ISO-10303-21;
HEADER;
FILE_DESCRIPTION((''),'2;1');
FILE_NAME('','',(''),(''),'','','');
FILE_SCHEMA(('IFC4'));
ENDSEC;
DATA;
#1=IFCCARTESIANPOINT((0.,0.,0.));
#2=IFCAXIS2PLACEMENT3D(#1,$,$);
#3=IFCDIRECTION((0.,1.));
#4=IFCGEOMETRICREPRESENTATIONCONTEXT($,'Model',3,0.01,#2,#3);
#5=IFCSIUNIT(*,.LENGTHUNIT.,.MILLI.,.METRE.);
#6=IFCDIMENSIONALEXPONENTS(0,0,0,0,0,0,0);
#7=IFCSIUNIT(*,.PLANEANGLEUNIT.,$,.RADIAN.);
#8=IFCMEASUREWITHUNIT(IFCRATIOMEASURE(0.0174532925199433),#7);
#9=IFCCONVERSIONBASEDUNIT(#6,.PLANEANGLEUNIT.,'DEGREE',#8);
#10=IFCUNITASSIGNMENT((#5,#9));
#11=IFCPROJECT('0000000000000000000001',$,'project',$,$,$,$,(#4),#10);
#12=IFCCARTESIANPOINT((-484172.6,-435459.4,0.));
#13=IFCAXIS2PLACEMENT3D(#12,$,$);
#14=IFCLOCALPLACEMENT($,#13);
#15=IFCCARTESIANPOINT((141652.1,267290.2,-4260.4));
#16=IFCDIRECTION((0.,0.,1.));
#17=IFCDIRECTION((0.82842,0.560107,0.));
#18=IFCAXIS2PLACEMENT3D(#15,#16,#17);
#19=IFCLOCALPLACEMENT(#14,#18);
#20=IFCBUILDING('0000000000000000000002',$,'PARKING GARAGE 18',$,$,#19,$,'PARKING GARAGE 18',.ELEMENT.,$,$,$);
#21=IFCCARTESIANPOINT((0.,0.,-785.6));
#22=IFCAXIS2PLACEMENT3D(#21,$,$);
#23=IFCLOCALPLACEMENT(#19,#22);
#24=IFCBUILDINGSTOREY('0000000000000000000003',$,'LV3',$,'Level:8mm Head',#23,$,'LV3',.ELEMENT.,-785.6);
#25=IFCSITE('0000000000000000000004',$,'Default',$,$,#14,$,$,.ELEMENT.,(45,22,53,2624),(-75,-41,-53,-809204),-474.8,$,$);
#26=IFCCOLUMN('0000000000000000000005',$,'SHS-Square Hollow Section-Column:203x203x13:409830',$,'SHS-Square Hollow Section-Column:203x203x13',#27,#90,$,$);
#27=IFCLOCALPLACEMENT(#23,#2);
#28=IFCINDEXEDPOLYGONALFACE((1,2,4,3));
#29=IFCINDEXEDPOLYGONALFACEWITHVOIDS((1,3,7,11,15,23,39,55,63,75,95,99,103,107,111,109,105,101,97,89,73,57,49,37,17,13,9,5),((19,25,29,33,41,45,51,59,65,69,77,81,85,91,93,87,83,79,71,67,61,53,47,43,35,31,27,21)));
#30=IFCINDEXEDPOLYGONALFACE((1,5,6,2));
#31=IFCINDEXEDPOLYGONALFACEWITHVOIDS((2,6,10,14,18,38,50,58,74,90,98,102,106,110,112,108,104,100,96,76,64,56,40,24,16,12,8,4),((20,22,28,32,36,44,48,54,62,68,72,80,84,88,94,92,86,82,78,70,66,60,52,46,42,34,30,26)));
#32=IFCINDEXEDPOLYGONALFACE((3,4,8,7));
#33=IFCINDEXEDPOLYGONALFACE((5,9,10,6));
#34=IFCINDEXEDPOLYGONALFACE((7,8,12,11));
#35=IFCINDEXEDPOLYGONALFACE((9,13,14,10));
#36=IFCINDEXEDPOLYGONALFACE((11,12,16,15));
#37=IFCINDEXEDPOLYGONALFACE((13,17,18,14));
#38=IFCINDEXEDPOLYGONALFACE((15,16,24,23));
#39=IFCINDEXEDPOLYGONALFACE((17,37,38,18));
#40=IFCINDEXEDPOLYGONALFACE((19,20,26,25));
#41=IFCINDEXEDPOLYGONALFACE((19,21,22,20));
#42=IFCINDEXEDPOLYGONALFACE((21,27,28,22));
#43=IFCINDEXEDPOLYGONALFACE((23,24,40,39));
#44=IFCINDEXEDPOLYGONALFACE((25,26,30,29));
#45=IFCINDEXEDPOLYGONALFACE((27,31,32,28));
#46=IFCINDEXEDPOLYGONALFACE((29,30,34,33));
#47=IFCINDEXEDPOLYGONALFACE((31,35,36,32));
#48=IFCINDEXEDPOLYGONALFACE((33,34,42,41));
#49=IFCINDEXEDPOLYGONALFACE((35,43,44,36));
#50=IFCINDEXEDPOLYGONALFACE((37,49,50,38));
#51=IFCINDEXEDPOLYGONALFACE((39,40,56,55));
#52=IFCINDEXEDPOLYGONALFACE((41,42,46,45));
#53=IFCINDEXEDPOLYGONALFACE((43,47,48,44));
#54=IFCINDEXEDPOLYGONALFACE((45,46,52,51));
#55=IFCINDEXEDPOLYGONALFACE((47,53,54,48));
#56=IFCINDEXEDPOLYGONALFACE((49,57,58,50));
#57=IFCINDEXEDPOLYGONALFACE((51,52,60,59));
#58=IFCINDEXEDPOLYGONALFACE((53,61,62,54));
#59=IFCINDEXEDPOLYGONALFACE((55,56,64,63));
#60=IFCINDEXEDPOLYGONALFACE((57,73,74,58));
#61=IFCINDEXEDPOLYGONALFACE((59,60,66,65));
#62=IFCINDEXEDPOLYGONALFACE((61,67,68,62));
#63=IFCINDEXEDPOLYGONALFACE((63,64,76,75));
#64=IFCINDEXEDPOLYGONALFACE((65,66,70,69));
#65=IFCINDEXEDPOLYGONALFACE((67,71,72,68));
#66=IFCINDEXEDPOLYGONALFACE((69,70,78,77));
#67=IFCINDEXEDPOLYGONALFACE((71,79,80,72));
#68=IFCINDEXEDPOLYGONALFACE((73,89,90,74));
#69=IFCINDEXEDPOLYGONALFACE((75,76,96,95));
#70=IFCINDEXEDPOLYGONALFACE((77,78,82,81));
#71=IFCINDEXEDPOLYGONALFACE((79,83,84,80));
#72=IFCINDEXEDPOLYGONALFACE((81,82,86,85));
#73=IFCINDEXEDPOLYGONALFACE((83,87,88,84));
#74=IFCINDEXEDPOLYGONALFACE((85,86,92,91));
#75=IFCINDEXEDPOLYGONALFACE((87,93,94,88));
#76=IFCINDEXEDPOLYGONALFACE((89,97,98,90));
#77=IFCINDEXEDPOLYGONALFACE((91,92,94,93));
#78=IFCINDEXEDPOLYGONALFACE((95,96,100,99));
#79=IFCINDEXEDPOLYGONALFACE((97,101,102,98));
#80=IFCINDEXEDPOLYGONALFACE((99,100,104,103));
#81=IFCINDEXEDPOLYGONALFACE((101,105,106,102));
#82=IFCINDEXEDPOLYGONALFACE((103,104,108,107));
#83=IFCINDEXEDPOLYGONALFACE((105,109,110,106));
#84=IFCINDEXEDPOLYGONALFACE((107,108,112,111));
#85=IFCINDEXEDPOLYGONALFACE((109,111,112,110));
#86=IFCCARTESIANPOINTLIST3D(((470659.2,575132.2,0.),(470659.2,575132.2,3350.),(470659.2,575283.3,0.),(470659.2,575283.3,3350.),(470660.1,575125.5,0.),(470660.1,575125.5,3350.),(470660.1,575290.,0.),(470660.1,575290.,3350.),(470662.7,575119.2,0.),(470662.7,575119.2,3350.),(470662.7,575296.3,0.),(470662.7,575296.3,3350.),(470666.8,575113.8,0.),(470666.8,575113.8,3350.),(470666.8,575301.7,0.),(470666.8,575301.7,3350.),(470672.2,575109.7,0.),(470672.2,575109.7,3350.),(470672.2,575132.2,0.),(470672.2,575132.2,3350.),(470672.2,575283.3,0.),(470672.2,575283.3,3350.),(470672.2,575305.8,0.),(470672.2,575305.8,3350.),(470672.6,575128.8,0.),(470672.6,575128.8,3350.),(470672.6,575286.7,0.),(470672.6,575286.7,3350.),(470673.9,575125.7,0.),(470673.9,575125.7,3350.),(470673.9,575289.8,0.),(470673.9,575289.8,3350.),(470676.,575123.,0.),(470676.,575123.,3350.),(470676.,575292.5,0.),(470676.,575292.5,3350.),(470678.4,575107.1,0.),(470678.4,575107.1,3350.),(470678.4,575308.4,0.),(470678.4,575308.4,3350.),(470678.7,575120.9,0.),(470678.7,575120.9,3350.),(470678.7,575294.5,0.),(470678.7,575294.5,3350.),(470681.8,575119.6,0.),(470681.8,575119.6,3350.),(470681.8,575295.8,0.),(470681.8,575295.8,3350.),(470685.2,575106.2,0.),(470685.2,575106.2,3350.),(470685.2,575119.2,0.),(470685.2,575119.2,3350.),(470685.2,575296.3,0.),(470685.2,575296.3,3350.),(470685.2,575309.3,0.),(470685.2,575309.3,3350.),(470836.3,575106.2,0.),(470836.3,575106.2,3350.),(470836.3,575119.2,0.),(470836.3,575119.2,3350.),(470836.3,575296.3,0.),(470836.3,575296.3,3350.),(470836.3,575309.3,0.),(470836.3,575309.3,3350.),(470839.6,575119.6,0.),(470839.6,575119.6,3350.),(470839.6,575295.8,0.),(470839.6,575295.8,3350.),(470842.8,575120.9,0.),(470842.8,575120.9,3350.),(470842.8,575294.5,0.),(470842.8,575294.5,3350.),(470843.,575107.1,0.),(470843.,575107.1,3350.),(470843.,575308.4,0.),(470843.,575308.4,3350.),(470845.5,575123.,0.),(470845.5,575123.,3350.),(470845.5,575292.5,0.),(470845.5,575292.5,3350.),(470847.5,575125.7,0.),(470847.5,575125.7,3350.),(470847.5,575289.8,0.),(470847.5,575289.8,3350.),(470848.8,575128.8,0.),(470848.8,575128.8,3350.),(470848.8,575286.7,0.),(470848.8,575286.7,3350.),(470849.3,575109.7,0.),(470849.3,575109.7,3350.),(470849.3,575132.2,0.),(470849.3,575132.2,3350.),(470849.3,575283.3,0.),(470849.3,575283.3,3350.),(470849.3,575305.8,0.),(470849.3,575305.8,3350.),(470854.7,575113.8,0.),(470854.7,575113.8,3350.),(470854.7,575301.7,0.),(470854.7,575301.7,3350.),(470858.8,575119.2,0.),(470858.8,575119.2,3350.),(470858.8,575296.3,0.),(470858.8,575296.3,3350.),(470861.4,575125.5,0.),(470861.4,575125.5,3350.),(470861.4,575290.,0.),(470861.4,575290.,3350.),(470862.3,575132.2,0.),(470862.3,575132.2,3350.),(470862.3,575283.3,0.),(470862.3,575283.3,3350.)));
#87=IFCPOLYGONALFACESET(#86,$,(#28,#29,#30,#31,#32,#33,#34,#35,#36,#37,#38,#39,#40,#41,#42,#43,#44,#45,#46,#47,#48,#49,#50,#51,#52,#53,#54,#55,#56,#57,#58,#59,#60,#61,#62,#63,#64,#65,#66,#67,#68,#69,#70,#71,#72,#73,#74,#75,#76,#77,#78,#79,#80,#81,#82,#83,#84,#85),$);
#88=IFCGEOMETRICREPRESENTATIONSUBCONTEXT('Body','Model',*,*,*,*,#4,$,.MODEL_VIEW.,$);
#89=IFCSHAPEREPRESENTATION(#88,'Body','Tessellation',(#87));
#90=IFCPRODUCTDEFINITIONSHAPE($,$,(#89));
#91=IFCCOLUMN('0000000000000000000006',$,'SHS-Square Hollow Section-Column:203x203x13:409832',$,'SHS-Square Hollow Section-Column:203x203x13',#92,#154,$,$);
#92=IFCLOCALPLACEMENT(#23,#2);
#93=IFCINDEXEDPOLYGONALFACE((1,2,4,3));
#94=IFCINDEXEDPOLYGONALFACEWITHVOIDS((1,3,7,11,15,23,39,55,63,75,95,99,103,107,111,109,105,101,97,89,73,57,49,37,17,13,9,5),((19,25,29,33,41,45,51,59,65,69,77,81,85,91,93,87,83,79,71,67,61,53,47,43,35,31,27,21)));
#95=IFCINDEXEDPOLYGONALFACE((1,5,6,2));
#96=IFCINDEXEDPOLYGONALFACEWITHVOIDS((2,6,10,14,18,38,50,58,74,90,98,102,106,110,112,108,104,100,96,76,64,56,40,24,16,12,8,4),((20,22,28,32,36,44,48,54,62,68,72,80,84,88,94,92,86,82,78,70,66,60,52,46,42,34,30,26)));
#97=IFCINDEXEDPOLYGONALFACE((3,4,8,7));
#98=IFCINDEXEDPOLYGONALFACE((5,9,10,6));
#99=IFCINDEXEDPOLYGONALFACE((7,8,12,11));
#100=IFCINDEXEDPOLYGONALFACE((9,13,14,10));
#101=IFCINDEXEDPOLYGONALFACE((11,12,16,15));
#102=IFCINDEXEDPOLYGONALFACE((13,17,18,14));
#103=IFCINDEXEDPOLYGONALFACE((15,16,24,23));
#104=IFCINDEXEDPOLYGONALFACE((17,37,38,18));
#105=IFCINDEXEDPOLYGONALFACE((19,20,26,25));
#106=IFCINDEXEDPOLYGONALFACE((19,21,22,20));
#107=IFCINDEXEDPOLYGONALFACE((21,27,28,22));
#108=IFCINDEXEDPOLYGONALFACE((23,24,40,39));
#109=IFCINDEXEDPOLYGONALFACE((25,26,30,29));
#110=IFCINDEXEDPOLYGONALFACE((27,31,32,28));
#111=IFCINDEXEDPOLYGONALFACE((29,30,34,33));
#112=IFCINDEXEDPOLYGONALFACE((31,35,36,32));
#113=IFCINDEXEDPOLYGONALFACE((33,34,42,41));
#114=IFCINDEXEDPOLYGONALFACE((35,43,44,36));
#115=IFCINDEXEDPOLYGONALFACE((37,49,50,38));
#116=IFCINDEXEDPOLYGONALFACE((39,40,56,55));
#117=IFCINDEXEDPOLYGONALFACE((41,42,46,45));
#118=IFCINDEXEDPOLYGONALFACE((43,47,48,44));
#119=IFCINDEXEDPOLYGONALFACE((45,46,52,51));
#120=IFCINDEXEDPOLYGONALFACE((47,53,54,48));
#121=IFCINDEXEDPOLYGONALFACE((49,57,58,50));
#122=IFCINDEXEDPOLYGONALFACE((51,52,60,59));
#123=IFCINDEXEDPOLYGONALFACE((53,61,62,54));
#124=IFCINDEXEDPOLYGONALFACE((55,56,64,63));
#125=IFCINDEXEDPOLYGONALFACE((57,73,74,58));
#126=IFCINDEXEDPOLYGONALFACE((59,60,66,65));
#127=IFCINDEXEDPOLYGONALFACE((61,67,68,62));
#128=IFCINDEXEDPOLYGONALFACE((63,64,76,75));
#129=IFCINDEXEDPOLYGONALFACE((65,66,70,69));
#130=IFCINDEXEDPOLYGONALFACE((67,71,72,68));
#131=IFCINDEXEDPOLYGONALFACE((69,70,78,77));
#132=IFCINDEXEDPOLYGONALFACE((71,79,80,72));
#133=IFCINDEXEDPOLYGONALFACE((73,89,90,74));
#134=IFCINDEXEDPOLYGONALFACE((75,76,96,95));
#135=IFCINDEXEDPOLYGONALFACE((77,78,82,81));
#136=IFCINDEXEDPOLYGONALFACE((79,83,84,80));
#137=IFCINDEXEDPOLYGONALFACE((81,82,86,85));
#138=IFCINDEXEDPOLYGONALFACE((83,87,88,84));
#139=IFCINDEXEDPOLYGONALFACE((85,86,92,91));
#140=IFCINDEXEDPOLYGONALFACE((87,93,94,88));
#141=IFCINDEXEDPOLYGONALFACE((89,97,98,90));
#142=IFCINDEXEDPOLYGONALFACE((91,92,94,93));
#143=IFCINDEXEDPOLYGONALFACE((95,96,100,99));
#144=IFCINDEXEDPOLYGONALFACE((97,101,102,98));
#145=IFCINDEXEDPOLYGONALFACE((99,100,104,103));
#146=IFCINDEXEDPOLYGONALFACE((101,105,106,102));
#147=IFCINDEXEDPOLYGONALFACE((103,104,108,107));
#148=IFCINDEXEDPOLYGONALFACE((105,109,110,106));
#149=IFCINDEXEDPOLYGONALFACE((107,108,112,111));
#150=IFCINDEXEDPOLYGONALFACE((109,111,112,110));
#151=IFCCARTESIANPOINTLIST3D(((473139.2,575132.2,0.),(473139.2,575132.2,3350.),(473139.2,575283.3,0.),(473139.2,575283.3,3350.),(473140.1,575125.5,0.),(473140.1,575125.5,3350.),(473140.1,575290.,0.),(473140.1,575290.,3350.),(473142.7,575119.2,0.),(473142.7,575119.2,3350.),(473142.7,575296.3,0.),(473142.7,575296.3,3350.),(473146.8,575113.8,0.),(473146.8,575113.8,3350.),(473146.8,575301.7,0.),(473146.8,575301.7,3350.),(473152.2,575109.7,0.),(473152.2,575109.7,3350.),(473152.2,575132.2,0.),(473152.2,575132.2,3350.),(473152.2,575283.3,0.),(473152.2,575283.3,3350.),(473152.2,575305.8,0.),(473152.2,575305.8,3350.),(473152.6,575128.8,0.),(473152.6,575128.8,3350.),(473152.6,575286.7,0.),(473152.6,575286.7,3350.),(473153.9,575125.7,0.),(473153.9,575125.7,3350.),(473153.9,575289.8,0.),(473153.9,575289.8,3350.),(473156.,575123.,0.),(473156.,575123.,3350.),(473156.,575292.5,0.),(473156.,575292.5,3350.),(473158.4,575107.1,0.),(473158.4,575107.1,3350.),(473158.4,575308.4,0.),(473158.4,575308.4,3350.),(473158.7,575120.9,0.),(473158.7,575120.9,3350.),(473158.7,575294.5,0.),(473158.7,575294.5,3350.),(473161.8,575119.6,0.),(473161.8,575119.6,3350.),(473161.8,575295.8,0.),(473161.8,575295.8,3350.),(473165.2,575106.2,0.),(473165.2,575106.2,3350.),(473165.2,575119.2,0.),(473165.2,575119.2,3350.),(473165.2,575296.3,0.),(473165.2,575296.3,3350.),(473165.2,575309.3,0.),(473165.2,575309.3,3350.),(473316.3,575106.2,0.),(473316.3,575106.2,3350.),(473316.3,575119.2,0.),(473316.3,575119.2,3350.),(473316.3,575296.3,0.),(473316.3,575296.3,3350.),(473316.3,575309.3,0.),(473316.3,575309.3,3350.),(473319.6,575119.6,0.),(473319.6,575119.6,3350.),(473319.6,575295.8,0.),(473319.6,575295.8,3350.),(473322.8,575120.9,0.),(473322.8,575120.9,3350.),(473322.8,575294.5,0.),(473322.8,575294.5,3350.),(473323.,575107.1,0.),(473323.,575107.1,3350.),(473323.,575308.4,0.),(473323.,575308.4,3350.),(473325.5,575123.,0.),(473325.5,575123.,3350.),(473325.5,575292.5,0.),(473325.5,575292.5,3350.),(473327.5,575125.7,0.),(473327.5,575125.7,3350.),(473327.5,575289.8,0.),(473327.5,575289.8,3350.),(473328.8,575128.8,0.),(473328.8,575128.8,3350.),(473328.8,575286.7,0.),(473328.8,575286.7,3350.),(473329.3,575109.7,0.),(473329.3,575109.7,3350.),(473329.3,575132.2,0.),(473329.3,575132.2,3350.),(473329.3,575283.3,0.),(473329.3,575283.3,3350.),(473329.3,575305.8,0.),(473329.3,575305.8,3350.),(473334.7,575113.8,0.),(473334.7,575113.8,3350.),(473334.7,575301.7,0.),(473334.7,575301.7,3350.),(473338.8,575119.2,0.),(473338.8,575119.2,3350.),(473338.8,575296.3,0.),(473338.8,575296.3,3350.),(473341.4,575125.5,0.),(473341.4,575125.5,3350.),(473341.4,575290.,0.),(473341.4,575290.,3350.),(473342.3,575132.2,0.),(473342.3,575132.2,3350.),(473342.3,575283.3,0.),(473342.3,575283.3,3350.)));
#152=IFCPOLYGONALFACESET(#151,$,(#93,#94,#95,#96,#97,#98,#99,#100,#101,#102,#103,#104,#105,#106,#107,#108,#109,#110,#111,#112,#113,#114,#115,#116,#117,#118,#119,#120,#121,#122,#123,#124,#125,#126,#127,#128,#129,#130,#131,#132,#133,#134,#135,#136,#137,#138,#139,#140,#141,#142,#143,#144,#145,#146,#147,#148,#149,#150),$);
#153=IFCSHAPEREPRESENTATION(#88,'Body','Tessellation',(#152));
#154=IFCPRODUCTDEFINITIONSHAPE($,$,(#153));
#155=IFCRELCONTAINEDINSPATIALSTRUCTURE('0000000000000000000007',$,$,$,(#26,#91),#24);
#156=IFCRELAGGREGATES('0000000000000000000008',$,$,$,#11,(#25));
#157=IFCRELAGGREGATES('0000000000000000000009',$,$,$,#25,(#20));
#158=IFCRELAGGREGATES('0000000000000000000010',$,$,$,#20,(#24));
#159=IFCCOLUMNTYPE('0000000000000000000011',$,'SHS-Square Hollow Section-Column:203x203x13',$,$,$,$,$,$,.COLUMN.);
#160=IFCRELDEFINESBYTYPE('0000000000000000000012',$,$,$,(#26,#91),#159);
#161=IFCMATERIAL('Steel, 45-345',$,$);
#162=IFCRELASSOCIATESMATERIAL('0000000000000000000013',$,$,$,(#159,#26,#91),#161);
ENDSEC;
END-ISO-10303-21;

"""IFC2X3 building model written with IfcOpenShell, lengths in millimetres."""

from ifc_helpers import new_model, entity, si_unit, converted_unit, direction, frame, frame_2d, origin, place, context, subcontext, project, spatial, polyline, circle_curve, parameter, trimmed, segment, composite_curve, outline, extrude, source, transform, mapped, material, type_object, type_shapes, element, save


model = new_model("IFC2X3")

# Units and contexts
model_context = context("Model", 3, precision=0.01, world=origin(), true_north=direction((0.0, 1.0)))
body_context = subcontext(model_context, "Body", "Model", "MODEL_VIEW")
ifc_project = project(units=[si_unit("LENGTHUNIT", "METRE", prefix="MILLI"), converted_unit("PLANEANGLEUNIT", "DEGREE", entity("IfcRatioMeasure", 0.0174532925199433), si_unit("PLANEANGLEUNIT", "RADIAN"), dimensions=[0, 0, 0, 0, 0, 0, 0])], contexts=[model_context])

# Site, building, storey
site_placement = place(None, frame((-484172.6, -435459.4, 0.0)))
site = spatial("IfcSite", under=ifc_project, at=site_placement, Name="Default", CompositionType="ELEMENT", RefLatitude=(45, 22, 53, 2624), RefLongitude=(-75, -41, -53, -809204), RefElevation=-474.8)
building_placement = place(site_placement, frame((141652.1, 267290.2, -4260.4), z_axis=(0.0, 0.0, 1.0), x_axis=(0.82842, 0.560107, 0.0)))
building = spatial("IfcBuilding", under=site, at=building_placement, Name="PARKING GARAGE 18", LongName="PARKING GARAGE 18", CompositionType="ELEMENT")
storey_placement = place(building_placement, frame((0.0, 0.0, -785.6)))
storey = spatial("IfcBuildingStorey", under=building, at=storey_placement, Name="LV3", ObjectType="Level:8mm Head", LongName="LV3", CompositionType="ELEMENT", Elevation=-785.6)

# Columns
ifc_material_1 = material(Name="Steel, 45-345")
column_type_1 = type_object("IfcColumnType", Name="SHS-Square Hollow Section-Column:203x203x13", PredefinedType="COLUMN", material=ifc_material_1)
shared_shape_1 = source(origin(), body_context, "Body", "SweptSolid", [
    extrude(outline(composite_curve([segment(polyline([(-75.6, -101.5), (75.6, -101.5)]), True, "CONTINUOUS"), segment(trimmed(circle_curve(frame_2d((75.6, -75.6), x_axis=(-1.0, 0.0)), 26.0), [parameter(90.0)], [parameter(180.0)], True, "PARAMETER"), True, "CONTINUOUS"), segment(polyline([(101.5, -75.6), (101.5, 75.6)]), True, "CONTINUOUS"), segment(trimmed(circle_curve(frame_2d((75.5, 75.6), x_axis=(-1.0, 0.0)), 26.0), [parameter(180.0)], [parameter(270.0)], True, "PARAMETER"), True, "CONTINUOUS"), segment(polyline([(75.5, 101.6), (-75.5, 101.6)]), True, "CONTINUOUS"), segment(trimmed(circle_curve(frame_2d((-75.5, 75.5), x_axis=(-1.0, 0.0)), 26.0), [parameter(270.0)], [parameter(360.0)], True, "PARAMETER"), True, "CONTINUOUS"), segment(polyline([(-101.5, 75.5), (-101.5, -75.6)]), True, "CONTINUOUS"), segment(trimmed(circle_curve(frame_2d((-75.6, -75.6), x_axis=(-1.0, 0.0)), 26.0), [parameter(360.0)], [parameter(90.0)], True, "PARAMETER"), True, "CONTINUOUS")], self_intersect=False), holes=[composite_curve([segment(trimmed(circle_curve(frame_2d((-75.6, -75.6), x_axis=(-1.0, 0.0)), 13.0), [parameter(0.0)], [parameter(90.0)], True, "PARAMETER"), False, "CONTINUOUS"), segment(polyline([(-88.5, -75.6), (-88.5, 75.6)]), True, "CONTINUOUS"), segment(trimmed(circle_curve(frame_2d((-75.6, 75.6), x_axis=(-1.0, 0.0)), 13.0), [parameter(270.0)], [parameter(0.0)], True, "PARAMETER"), False, "CONTINUOUS"), segment(polyline([(-75.6, 88.6), (75.5, 88.6)]), True, "CONTINUOUS"), segment(trimmed(circle_curve(frame_2d((75.5, 75.5), x_axis=(-1.0, 0.0)), 13.0), [parameter(180.0)], [parameter(270.0)], True, "PARAMETER"), False, "CONTINUOUS"), segment(polyline([(88.6, 75.5), (88.6, -75.5)]), True, "CONTINUOUS"), segment(trimmed(circle_curve(frame_2d((75.6, -75.5), x_axis=(-1.0, 0.0)), 13.0), [parameter(90.0)], [parameter(180.0)], True, "PARAMETER"), False, "CONTINUOUS"), segment(polyline([(75.6, -88.5), (-75.6, -88.5)]), True, "CONTINUOUS")], self_intersect=False)]), frame((0.0, 0.0, -785.6), z_axis=(0.0, 0.0, 1.0), x_axis=(-1.0, 0.0, 0.0)), (0.0, 0.0, 1.0), 3350.0),
])
type_shapes(column_type_1, [shared_shape_1])
for number, where, name in (
    (1, (470760.7, 575207.7, 785.6), "SHS-Square Hollow Section-Column:203x203x13:409830"),
    (2, (473240.7, 575207.7, 785.6), "SHS-Square Hollow Section-Column:203x203x13:409832"),
):
    element("IfcColumn", number, at=place(storey_placement, frame(where)), inside=storey, type_object=column_type_1, material=ifc_material_1, Name=name, ObjectType="SHS-Square Hollow Section-Column:203x203x13", context=body_context, shape_type="MappedRepresentation", body=[
        mapped(shared_shape_1, transform((0.0, 0.0, 0.0), scale=1.0)),
    ])

save(model, "model.ifc")
